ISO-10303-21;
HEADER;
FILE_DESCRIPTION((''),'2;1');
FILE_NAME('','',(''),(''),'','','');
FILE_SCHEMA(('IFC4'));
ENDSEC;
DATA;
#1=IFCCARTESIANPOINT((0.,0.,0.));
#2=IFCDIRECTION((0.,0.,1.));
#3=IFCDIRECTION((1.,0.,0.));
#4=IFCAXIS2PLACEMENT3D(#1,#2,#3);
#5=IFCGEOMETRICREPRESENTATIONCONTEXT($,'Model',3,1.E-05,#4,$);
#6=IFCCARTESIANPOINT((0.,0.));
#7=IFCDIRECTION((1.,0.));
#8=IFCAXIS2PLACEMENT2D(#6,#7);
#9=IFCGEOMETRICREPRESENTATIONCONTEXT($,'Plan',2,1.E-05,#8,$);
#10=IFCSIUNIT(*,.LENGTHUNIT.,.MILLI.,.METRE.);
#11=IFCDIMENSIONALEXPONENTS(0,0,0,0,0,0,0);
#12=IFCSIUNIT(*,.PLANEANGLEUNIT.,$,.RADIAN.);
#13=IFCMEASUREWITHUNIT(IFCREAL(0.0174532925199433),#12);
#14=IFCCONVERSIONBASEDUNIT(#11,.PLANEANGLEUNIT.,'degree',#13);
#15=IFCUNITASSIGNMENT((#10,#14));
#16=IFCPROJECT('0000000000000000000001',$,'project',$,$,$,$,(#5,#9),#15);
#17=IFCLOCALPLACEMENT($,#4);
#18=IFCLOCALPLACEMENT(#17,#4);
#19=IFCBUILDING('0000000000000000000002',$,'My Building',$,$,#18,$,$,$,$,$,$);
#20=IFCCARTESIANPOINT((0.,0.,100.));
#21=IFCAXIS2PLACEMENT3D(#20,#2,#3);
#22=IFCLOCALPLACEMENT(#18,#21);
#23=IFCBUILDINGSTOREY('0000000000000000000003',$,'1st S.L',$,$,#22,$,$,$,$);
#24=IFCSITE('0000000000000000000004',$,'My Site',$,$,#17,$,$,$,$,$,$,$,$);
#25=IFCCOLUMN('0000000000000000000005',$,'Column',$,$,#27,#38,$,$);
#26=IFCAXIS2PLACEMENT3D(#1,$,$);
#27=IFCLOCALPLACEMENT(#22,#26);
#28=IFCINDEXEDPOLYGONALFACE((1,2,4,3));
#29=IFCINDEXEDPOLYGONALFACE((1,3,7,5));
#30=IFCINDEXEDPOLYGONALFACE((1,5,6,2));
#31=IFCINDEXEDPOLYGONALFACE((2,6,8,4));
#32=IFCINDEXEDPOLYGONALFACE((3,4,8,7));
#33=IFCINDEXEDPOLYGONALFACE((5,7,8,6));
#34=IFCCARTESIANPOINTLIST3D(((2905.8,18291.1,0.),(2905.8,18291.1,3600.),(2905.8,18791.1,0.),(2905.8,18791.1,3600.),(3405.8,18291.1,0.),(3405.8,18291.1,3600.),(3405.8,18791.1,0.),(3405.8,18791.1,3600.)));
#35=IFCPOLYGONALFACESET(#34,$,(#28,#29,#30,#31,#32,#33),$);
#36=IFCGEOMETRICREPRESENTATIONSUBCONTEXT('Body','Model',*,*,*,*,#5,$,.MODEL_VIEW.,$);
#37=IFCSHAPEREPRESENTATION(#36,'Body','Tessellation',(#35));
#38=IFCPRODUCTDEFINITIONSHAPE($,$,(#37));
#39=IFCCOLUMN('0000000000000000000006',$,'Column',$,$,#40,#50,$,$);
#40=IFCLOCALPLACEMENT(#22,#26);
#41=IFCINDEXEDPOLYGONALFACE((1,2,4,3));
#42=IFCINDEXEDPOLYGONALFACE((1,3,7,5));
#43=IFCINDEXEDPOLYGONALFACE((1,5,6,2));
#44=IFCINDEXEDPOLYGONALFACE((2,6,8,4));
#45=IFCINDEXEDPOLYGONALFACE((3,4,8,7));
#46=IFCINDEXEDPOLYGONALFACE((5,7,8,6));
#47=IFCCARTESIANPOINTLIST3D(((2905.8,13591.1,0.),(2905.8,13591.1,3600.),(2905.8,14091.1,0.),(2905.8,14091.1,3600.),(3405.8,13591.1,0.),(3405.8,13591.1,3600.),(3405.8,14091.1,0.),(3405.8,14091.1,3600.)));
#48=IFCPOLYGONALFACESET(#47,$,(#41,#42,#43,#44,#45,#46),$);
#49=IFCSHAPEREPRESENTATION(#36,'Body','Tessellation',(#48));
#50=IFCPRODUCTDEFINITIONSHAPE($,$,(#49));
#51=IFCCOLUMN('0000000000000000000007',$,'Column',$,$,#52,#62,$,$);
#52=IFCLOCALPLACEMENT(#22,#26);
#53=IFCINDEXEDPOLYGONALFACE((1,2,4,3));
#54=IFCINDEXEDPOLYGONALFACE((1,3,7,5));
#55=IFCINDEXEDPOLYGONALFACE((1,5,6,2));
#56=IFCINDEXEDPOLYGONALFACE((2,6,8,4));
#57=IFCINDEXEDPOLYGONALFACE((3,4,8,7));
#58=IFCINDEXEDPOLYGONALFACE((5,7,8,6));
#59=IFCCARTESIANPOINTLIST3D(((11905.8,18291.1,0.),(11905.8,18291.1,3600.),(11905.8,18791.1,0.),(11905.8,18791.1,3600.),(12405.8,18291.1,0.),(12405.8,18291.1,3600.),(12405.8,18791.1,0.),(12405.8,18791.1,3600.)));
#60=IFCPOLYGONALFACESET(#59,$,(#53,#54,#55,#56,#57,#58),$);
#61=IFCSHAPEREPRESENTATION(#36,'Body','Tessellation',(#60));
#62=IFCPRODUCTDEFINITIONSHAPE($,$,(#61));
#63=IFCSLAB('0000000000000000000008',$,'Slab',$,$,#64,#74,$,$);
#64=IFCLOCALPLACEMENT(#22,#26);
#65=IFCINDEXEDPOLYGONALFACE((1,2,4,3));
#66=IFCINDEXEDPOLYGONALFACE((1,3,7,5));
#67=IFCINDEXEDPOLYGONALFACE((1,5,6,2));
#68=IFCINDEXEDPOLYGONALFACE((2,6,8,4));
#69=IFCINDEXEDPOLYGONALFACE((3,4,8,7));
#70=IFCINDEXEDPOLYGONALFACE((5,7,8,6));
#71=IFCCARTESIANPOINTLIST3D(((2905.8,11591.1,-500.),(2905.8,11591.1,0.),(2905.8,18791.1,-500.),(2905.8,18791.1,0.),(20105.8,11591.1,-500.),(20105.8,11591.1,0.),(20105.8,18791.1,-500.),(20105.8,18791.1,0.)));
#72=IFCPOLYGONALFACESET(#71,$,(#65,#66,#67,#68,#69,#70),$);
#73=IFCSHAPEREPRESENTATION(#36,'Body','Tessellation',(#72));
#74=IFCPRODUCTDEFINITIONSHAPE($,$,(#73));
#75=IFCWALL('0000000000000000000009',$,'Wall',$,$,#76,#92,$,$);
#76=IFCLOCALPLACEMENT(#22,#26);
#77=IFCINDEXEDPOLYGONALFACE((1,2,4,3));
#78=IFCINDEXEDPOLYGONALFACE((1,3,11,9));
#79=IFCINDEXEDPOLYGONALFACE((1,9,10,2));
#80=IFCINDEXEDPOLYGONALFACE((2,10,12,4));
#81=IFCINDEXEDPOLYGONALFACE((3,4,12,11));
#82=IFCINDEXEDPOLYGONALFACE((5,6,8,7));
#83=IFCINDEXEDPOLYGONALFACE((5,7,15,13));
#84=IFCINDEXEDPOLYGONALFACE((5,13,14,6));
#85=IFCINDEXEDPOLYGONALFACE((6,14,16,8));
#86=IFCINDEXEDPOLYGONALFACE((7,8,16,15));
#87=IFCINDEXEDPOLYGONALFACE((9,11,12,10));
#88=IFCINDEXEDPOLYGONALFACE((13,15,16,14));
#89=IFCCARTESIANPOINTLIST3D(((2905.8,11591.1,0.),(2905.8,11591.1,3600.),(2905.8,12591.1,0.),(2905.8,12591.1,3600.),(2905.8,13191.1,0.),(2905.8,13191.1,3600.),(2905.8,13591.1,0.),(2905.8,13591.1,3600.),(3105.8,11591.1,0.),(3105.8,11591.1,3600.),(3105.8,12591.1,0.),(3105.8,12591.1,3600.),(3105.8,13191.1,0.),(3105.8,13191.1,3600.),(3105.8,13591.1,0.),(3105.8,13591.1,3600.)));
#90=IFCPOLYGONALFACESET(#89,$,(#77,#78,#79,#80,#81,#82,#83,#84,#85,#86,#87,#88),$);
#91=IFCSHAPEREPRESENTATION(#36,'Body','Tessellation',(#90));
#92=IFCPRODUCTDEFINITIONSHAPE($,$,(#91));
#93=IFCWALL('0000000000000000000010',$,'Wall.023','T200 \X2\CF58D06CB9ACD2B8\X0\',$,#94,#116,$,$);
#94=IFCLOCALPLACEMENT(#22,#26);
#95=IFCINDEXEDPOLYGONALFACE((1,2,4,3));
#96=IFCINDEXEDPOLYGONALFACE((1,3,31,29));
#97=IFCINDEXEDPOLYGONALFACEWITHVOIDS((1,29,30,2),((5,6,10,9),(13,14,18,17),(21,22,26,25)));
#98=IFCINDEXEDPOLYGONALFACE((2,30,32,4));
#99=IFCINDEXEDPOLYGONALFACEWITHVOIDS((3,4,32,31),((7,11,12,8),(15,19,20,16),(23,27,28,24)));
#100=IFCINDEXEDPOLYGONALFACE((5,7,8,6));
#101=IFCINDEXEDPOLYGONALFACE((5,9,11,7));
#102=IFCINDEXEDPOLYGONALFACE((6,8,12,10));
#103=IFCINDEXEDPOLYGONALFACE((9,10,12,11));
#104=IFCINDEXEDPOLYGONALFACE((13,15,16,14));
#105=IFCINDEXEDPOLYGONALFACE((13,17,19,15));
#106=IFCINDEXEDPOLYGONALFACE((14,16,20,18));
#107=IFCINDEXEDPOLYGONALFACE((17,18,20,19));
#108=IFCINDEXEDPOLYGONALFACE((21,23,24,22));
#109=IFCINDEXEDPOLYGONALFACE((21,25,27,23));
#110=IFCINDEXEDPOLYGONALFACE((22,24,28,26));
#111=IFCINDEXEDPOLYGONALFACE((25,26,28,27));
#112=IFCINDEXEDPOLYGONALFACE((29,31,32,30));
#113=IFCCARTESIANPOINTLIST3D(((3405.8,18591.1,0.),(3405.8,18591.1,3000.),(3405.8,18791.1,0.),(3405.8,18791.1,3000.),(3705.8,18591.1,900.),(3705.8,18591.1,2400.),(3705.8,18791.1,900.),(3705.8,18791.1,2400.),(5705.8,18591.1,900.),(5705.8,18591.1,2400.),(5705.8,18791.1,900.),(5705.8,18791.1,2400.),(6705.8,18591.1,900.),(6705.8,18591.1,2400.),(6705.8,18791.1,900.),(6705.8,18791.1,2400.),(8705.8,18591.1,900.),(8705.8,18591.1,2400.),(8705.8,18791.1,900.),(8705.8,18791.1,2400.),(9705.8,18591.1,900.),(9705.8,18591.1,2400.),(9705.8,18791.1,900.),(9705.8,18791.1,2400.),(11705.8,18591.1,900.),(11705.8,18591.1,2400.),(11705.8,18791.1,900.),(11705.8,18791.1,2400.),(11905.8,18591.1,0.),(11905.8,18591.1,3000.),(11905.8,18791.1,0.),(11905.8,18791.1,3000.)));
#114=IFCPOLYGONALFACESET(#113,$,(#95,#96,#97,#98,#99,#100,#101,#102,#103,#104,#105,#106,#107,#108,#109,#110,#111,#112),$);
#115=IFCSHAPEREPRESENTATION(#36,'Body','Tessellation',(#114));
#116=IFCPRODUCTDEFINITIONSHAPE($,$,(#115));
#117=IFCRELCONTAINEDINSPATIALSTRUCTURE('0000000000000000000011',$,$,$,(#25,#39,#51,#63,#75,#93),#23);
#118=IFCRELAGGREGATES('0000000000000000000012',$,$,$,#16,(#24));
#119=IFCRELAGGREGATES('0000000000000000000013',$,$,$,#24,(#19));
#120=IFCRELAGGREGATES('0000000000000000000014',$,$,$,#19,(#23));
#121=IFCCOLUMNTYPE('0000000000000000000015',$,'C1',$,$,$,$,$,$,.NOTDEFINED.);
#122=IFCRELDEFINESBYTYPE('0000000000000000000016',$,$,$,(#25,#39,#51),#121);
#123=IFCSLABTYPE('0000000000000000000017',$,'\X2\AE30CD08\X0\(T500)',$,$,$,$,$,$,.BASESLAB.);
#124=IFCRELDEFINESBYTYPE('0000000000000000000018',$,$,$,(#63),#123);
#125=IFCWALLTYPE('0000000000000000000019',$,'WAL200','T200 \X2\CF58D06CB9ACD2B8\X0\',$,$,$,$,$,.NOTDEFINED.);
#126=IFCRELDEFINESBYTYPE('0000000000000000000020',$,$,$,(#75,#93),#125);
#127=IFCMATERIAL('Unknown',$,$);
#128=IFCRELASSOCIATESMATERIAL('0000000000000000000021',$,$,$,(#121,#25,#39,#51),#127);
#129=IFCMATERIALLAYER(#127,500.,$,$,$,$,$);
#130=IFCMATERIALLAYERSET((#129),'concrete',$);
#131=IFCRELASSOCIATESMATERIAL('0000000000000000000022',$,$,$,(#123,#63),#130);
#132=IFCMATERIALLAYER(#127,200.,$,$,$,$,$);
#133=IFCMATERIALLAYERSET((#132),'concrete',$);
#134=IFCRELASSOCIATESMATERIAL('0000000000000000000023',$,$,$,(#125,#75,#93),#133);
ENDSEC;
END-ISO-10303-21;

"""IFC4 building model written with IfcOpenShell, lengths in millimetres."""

from ifc_helpers import new_model, entity, si_unit, converted_unit, frame, origin_with_axes, origin_2d_with_axis, place, context, subcontext, project, spatial, line, indexed_curve, rectangle, outline, extrude, source, transform, mapped, material, layer, layer_set, layer_usage, material_profile, profile_set, profile_usage, type_object, element, save


model = new_model("IFC4")

# Units and contexts
model_context = context("Model", 3, precision=1e-05, world=origin_with_axes())
plan_context = context("Plan", 2, precision=1e-05, world=origin_2d_with_axis())
body_context_1 = subcontext(model_context, "Body", "Model", "MODEL_VIEW")
ifc_project = project(units=[si_unit("LENGTHUNIT", "METRE", prefix="MILLI"), converted_unit("PLANEANGLEUNIT", "degree", entity("IfcReal", 0.0174532925199433), si_unit("PLANEANGLEUNIT", "RADIAN"), dimensions=[0, 0, 0, 0, 0, 0, 0])], contexts=[model_context, plan_context])

# Site, building, storey
site_placement = place(None, origin_with_axes())
site = spatial("IfcSite", under=ifc_project, at=site_placement, Name="My Site")
building_placement = place(site_placement, origin_with_axes())
building = spatial("IfcBuilding", under=site, at=building_placement, Name="My Building")
storey_placement = place(building_placement, frame((0.0, 0.0, 100.0), z_axis=(0.0, 0.0, 1.0), x_axis=(1.0, 0.0, 0.0)))
storey = spatial("IfcBuildingStorey", under=building, at=storey_placement, Name="1st S.L")

# Shared definitions
ifc_material_1 = material(Name="Unknown")

# Columns
ifc_material_profile = material_profile(ifc_material_1, rectangle(XDim=500.0, YDim=500.0, kind="CURVE"))
ifc_profile_set = profile_set([ifc_material_profile], Name="concrete")
ifc_profile_usage_1 = profile_usage(ifc_profile_set, cardinal=5)
column_type = type_object("IfcColumnType", Name="C1", PredefinedType="NOTDEFINED", material=ifc_profile_set)
column_1_placement = place(storey_placement, frame((3155.8, 18541.1, 0.0), z_axis=(0.0, 0.0, 1.0), x_axis=(1.0, 0.0, 0.0)))
element("IfcColumn", 1, at=column_1_placement, inside=storey, type_object=column_type, material=ifc_profile_usage_1, Name="Column", context=body_context_1, shape_type="SweptSolid", body=[
    extrude(rectangle(XDim=500.0, YDim=500.0, kind="CURVE"), origin_with_axes(), (0.0, 0.0, 1.0), 3600.0),
])
ifc_profile_usage_2 = profile_usage(ifc_profile_set, cardinal=5)
column_2_placement = place(storey_placement, frame((3155.8, 13841.1, 0.0), z_axis=(0.0, 0.0, 1.0), x_axis=(1.0, 0.0, 0.0)))
element("IfcColumn", 2, at=column_2_placement, inside=storey, type_object=column_type, material=ifc_profile_usage_2, Name="Column", context=body_context_1, shape_type="SweptSolid", body=[
    extrude(rectangle(XDim=500.0, YDim=500.0, kind="CURVE"), origin_with_axes(), (0.0, 0.0, 1.0), 3600.0),
])
ifc_profile_usage_3 = profile_usage(ifc_profile_set, cardinal=5)
column_3_placement = place(storey_placement, frame((12155.8, 18541.1, 0.0), z_axis=(0.0, 0.0, 1.0), x_axis=(1.0, 0.0, 0.0)))
element("IfcColumn", 3, at=column_3_placement, inside=storey, type_object=column_type, material=ifc_profile_usage_3, Name="Column", context=body_context_1, shape_type="SweptSolid", body=[
    extrude(rectangle(XDim=500.0, YDim=500.0, kind="CURVE"), origin_with_axes(), (0.0, 0.0, 1.0), 3600.0),
])

# Slab
ifc_layer_1 = layer(ifc_material_1, 500.0)
ifc_layer_set_1 = layer_set([ifc_layer_1], Name="concrete")
ifc_layer_usage_1 = layer_usage(ifc_layer_set_1, "AXIS3", "POSITIVE", -500.0)
slab_type = type_object("IfcSlabType", Name="기초(T500)", PredefinedType="BASESLAB", material=ifc_layer_set_1)
slab_placement = place(storey_placement, frame((2905.8, 18791.1, 0.0), z_axis=(0.0, 0.0, 1.0), x_axis=(1.0, 0.0, 0.0)))
element("IfcSlab", 4, at=slab_placement, inside=storey, type_object=slab_type, material=ifc_layer_usage_1, Name="Slab", context=body_context_1, shape_type="SolidModel", body=[
    extrude(outline(indexed_curve([(0.0, 0.0), (17200.0, 0.0), (17200.0, -7200.0), (0.0, -7200.0), (0.0, 0.0)])), frame((0.0, 0.0, -500.0), z_axis=(0.0, 0.0, 1.0), x_axis=(1.0, 0.0, 0.0)), (0.0, 0.0, 1.0), 500.0),
])

# Wall, opening
ifc_layer_2 = layer(ifc_material_1, 200.0)
ifc_layer_set_2 = layer_set([ifc_layer_2], Name="concrete")
ifc_layer_usage_2 = layer_usage(ifc_layer_set_2, "AXIS2", "POSITIVE", 0.0)
wall_type = type_object("IfcWallType", Name="WAL200", Description="T200 콘크리트", PredefinedType="NOTDEFINED", material=ifc_layer_set_2)
wall_1_placement = place(storey_placement, frame((3105.8, 11591.1, 0.0), z_axis=(0.0, 0.0, 1.0), x_axis=(0.0, 1.0, 0.0)))
wall_1 = element("IfcWall", 5, at=wall_1_placement, inside=storey, type_object=wall_type, material=ifc_layer_usage_2, Name="Wall", context=body_context_1, shape_type="SweptSolid", body=[
    extrude(outline(indexed_curve([(0.0, 0.0), (0.0, 200.0), (2000.0, 200.0), (2000.0, 0.0), (0.0, 0.0)], self_intersect=False)), origin_with_axes(), (0.0, 0.0, 1.0), 3600.0),
])
shared_shape_1 = source(origin_with_axes(), body_context_1, "Body", "SolidModel", [
    extrude(outline(indexed_curve([(0.0, 0.0), (600.0, 0.0), (600.0, 4800.0), (0.0, 4800.0)], segments=[line(1, 2, 3, 4, 1)])), frame((0.0, -600.0, 0.0), z_axis=(0.0, -1.0, 0.0), x_axis=(1.0, 0.0, 0.0)), (0.0, 0.0, -1.0), 1200.0),
])
opening_1_placement = place(wall_1_placement, frame((1000.0, 0.0, 0.0), z_axis=(0.0, 0.0, 1.0), x_axis=(1.0, 0.0, 0.0)))
element("IfcOpeningElement", 6, at=opening_1_placement, cuts=wall_1, PredefinedType="OPENING", context=body_context_1, shape_type="MappedRepresentation", body=[
    mapped(shared_shape_1, transform((0.0, 0.0, 0.0), x_axis=(1.0, 0.0, 0.0), y_axis=(0.0, 1.0, 0.0), z_axis=(0.0, 0.0, 1.0), scale=1.0)),
])

# Wall, openings
ifc_layer_usage_3 = layer_usage(ifc_layer_set_2, "AXIS2", "POSITIVE", 0.0)
wall_2_placement = place(storey_placement, frame((3405.8, 18591.1, 0.0), z_axis=(0.0, 0.0, 1.0), x_axis=(1.0, 0.0, 0.0)))
wall_2 = element("IfcWall", 7, at=wall_2_placement, inside=storey, type_object=wall_type, material=ifc_layer_usage_3, Name="Wall.023", Description="T200 콘크리트", context=body_context_1, shape_type="SweptSolid", body=[
    extrude(outline(indexed_curve([(0.0, 0.0), (0.0, 200.0), (8500.0, 200.0), (8500.0, 0.0), (0.0, 0.0)], self_intersect=False)), origin_with_axes(), (0.0, 0.0, 1.0), 3000.0),
])
shared_shape_2 = source(origin_with_axes(), body_context_1, "Body", "SolidModel", [
    extrude(outline(indexed_curve([(0.0, 0.0), (2000.0, 0.0), (2000.0, 1500.0), (0.0, 1500.0)], segments=[line(1, 2, 3, 4, 1)])), frame((0.0, -600.0, 0.0), z_axis=(0.0, -1.0, 0.0), x_axis=(1.0, 0.0, 0.0)), (0.0, 0.0, -1.0), 1200.0),
])
opening_2_placement = place(wall_2_placement, frame((3300.0, 0.0, 900.0), z_axis=(0.0, 0.0, 1.0), x_axis=(1.0, 0.0, 0.0)))
element("IfcOpeningElement", 8, at=opening_2_placement, cuts=wall_2, PredefinedType="OPENING", context=body_context_1, shape_type="MappedRepresentation", body=[
    mapped(shared_shape_2, transform((0.0, 0.0, 0.0), x_axis=(1.0, 0.0, 0.0), y_axis=(0.0, 1.0, 0.0), z_axis=(0.0, 0.0, 1.0), scale=1.0)),
])
opening_3_placement = place(wall_2_placement, frame((300.0, 0.0, 900.0), z_axis=(0.0, 0.0, 1.0), x_axis=(1.0, 0.0, 0.0)))
element("IfcOpeningElement", 9, at=opening_3_placement, cuts=wall_2, PredefinedType="OPENING", context=body_context_1, shape_type="MappedRepresentation", body=[
    mapped(shared_shape_2, transform((0.0, 0.0, 0.0), x_axis=(1.0, 0.0, 0.0), y_axis=(0.0, 1.0, 0.0), z_axis=(0.0, 0.0, 1.0), scale=1.0)),
])
opening_4_placement = place(wall_2_placement, frame((6300.0, 0.0, 900.0), z_axis=(0.0, 0.0, 1.0), x_axis=(1.0, 0.0, 0.0)))
element("IfcOpeningElement", 10, at=opening_4_placement, cuts=wall_2, PredefinedType="OPENING", context=body_context_1, shape_type="MappedRepresentation", body=[
    mapped(shared_shape_2, transform((0.0, 0.0, 0.0), x_axis=(1.0, 0.0, 0.0), y_axis=(0.0, 1.0, 0.0), z_axis=(0.0, 0.0, 1.0), scale=1.0)),
])

save(model, "model.ifc")
